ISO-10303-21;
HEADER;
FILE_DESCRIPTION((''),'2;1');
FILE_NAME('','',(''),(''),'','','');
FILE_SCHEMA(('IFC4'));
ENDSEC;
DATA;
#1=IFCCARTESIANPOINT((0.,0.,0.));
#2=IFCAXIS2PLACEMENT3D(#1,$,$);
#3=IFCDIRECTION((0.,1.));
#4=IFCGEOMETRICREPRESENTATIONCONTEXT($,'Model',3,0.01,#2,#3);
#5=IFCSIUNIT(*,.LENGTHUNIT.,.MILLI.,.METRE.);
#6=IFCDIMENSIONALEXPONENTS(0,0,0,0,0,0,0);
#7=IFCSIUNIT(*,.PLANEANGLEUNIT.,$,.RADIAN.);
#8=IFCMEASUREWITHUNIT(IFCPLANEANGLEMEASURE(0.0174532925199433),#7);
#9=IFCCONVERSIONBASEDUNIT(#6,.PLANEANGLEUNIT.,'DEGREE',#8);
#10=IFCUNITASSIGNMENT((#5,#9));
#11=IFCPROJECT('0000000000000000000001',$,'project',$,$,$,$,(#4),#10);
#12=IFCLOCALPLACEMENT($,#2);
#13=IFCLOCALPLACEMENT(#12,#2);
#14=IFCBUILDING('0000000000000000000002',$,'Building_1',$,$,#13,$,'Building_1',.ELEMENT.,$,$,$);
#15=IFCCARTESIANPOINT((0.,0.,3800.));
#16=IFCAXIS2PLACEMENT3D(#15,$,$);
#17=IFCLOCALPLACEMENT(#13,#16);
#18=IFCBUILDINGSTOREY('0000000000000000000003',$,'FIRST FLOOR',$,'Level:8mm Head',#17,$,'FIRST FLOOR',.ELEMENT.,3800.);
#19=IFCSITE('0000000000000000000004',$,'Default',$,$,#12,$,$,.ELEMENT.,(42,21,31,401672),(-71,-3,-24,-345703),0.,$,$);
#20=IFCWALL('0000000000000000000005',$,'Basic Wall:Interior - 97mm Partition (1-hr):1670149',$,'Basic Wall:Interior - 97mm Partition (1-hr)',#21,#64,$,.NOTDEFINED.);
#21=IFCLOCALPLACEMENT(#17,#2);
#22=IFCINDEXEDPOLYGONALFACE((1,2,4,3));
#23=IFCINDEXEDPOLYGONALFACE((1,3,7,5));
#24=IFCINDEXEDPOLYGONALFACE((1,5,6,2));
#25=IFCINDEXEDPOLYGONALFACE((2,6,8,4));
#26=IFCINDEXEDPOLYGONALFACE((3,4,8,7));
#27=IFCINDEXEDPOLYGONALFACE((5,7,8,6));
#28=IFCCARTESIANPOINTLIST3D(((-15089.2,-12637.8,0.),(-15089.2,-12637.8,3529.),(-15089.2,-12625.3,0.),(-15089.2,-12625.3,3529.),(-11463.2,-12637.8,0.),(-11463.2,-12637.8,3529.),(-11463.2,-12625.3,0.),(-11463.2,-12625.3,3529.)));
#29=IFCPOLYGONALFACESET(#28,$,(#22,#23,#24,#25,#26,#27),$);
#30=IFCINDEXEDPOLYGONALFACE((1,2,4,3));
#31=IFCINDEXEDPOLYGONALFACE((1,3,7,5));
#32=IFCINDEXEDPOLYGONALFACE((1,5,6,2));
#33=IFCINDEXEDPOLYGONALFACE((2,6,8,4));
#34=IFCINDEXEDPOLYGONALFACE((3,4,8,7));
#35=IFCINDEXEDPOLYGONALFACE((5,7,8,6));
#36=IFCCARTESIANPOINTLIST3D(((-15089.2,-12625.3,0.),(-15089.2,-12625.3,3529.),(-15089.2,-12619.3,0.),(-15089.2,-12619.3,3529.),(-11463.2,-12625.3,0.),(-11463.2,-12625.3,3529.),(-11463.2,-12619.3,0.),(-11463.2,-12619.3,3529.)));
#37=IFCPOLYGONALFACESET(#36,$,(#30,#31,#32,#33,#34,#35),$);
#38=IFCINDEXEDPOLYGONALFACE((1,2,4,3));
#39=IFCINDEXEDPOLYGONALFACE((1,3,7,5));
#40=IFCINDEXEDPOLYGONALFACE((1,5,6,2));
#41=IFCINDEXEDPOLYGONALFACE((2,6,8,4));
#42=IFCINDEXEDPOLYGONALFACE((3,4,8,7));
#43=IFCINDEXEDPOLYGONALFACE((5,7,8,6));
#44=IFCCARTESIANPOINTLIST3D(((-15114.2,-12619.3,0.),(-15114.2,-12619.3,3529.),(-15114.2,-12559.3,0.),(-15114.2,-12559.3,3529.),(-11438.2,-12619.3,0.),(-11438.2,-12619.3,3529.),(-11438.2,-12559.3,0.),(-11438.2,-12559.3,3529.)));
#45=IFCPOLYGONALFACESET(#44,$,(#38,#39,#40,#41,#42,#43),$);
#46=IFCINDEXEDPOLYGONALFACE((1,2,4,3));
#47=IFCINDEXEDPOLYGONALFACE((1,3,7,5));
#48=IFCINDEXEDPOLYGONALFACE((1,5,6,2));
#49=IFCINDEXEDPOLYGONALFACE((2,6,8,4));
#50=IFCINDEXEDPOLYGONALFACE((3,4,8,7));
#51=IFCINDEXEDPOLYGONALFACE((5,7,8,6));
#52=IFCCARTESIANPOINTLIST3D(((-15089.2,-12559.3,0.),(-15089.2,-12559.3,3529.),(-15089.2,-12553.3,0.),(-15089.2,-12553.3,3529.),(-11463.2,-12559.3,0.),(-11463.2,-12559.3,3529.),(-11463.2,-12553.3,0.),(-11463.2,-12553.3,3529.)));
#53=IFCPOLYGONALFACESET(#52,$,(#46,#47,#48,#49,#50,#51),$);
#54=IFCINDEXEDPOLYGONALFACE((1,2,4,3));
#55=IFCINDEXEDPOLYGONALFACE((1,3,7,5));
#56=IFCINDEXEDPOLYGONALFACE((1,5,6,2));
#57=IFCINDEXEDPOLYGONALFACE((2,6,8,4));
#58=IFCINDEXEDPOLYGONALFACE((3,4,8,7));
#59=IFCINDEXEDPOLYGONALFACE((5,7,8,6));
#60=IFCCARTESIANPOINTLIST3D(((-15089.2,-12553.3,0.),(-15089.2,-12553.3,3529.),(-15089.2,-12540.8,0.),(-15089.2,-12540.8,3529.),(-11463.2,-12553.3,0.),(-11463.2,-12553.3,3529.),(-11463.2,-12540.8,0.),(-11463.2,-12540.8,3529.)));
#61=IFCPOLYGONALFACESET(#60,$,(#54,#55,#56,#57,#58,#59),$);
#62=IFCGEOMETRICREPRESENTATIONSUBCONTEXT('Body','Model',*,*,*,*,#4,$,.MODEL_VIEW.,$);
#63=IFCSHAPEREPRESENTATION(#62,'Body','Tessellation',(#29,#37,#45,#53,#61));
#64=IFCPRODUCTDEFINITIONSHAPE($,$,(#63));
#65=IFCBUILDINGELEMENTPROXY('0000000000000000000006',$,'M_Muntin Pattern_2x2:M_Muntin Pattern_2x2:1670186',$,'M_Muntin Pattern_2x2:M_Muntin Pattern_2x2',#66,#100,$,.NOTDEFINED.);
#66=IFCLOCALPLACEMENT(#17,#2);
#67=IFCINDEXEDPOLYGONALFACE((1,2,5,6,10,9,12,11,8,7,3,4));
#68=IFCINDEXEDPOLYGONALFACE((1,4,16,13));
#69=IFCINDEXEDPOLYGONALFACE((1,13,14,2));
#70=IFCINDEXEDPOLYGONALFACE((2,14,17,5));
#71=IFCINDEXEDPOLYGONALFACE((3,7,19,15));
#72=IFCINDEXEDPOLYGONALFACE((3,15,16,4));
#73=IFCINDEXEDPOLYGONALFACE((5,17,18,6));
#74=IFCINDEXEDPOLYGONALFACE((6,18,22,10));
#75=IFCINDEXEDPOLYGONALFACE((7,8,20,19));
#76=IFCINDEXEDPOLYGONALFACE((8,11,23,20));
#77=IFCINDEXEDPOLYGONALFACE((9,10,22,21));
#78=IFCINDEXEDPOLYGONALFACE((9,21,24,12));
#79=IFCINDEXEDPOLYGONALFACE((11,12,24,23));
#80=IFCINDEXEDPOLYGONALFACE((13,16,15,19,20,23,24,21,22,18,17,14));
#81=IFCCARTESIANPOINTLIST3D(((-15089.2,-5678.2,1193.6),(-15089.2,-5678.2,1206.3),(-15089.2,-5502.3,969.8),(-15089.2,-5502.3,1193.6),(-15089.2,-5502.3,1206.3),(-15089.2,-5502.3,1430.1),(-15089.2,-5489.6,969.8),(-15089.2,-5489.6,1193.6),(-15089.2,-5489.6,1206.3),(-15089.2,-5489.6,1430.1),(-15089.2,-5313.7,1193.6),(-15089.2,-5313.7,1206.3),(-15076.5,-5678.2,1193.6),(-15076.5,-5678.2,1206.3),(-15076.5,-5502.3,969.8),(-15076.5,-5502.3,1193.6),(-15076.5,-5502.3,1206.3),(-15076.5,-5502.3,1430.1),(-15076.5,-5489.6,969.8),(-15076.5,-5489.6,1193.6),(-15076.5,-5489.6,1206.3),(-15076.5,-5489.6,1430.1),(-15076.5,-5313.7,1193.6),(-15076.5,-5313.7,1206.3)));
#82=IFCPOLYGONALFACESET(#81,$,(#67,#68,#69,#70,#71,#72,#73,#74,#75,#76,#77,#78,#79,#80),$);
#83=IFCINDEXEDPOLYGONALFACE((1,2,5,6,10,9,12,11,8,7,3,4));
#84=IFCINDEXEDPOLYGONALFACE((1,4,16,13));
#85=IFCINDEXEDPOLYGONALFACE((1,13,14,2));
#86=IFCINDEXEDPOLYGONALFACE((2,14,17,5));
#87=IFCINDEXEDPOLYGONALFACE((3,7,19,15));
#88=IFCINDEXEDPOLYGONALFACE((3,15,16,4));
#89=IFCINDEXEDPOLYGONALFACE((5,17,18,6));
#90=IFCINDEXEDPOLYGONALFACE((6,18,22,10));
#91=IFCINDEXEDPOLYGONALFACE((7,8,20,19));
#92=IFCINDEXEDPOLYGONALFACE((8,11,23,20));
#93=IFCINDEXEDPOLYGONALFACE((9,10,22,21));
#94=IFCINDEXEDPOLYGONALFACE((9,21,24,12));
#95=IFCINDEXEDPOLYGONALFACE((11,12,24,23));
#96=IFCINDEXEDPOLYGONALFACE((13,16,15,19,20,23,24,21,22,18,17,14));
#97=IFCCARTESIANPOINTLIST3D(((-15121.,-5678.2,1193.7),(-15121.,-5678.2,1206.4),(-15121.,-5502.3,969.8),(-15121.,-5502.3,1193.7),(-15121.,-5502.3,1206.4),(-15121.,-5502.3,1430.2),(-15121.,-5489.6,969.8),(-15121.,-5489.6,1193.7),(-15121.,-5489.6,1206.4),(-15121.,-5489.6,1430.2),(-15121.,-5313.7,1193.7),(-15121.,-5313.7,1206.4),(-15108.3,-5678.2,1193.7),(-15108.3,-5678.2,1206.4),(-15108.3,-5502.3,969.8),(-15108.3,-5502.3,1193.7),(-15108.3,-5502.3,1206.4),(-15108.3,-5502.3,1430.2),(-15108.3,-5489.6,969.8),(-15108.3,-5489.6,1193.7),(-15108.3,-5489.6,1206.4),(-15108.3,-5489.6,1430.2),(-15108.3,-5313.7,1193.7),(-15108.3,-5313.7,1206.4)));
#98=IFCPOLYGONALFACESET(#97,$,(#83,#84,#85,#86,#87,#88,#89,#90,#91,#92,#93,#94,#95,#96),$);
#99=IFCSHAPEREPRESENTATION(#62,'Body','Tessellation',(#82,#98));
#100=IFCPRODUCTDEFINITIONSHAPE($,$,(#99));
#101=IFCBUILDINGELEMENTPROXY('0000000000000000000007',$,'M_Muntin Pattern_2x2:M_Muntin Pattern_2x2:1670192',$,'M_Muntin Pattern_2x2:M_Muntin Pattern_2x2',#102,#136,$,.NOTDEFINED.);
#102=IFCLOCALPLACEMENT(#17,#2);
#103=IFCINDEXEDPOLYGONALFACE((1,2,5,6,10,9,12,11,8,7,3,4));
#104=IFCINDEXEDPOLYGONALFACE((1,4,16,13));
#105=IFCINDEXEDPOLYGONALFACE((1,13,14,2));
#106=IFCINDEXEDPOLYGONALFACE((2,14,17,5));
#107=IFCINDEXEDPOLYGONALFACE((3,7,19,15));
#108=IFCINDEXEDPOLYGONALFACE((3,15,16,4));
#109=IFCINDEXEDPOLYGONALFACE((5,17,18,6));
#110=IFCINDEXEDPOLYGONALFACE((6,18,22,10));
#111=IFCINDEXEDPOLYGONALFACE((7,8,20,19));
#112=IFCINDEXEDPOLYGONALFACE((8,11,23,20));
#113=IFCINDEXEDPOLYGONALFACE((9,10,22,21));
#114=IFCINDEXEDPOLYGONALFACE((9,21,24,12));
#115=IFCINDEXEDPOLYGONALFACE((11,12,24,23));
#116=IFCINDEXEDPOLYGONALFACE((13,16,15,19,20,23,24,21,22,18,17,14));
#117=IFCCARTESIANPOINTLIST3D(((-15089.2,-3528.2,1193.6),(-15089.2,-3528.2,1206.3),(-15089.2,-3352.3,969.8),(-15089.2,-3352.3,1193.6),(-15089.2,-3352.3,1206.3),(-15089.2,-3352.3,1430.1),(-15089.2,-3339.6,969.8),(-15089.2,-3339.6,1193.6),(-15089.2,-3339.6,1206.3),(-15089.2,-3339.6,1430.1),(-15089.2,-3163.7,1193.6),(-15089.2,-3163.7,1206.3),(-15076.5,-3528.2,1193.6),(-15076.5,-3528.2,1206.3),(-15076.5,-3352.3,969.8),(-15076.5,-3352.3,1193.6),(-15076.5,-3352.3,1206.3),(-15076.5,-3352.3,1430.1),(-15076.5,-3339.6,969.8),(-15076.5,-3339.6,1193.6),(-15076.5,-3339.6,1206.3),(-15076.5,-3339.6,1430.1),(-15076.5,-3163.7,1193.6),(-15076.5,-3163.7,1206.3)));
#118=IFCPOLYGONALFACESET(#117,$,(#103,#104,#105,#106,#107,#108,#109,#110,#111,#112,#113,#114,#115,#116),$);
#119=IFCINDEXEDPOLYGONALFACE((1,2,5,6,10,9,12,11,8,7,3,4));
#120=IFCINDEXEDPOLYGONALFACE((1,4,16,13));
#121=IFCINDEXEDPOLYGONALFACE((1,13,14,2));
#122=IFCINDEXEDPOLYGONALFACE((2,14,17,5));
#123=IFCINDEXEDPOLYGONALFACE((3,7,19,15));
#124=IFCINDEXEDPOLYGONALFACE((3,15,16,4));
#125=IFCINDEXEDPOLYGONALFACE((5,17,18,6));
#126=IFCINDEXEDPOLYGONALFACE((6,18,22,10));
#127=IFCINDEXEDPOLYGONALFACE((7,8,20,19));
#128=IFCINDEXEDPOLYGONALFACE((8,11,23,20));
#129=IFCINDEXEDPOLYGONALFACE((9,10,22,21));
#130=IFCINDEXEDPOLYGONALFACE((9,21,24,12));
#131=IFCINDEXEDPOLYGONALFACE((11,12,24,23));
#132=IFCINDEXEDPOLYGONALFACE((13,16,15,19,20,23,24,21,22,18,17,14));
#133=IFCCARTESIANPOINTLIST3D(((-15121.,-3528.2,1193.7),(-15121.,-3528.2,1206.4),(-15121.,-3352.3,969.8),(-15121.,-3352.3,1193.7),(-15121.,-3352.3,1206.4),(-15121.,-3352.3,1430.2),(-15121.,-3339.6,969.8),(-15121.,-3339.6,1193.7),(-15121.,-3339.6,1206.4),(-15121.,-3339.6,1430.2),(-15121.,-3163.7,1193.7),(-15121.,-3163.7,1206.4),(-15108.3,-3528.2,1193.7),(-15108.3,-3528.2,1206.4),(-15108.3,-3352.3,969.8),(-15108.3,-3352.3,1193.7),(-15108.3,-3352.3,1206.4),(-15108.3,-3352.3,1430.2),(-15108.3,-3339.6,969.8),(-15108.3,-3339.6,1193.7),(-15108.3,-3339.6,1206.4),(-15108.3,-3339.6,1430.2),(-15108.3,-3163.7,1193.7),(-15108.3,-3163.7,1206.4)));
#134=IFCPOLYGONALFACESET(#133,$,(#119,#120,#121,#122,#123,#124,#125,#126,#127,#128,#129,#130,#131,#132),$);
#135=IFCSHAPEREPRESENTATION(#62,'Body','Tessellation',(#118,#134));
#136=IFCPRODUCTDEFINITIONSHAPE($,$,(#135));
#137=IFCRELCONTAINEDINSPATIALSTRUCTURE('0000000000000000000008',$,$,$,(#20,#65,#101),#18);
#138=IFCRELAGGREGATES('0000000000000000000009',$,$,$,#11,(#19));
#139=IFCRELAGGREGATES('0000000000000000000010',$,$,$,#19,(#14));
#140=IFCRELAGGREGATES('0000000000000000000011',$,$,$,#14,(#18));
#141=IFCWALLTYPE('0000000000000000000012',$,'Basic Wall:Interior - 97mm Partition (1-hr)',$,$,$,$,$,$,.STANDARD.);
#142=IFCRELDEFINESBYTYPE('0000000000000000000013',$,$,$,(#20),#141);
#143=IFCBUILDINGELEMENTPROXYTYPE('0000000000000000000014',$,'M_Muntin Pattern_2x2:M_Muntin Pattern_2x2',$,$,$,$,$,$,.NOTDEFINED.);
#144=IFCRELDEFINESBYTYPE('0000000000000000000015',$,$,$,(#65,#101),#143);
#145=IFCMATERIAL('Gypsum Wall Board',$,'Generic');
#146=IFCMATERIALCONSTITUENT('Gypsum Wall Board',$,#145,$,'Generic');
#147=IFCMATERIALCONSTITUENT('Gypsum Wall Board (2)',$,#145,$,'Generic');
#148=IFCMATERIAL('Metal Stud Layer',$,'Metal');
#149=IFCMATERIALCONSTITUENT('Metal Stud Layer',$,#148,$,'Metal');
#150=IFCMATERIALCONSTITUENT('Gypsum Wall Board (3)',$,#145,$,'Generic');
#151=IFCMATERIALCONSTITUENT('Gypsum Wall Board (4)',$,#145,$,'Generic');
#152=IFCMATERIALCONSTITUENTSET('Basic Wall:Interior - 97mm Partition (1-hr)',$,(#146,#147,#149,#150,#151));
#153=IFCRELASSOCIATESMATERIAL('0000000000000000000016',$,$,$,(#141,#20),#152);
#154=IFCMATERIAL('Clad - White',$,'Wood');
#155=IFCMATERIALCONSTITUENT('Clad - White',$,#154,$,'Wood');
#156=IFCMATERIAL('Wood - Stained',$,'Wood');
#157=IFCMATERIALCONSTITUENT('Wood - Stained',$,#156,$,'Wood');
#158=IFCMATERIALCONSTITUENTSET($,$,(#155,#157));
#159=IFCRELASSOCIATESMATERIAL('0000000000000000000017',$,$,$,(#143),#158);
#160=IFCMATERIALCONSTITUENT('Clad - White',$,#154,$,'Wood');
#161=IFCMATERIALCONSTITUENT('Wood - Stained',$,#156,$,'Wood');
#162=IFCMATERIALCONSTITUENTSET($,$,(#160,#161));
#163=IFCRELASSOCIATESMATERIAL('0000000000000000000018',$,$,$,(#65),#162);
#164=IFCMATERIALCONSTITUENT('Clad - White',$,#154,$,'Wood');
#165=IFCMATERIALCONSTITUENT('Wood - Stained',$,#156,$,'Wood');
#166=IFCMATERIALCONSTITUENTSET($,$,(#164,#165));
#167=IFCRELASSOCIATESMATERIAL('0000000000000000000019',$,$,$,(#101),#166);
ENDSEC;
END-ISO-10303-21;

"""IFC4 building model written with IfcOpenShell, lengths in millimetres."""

from ifc_helpers import new_model, entity, si_unit, converted_unit, direction, frame, origin, place, context, subcontext, project, spatial, indexed_curve, outline, extrude, source, transform, mapped, material, constituent, constituent_set, type_object, type_shapes, element, save


model = new_model("IFC4")

# Units and contexts
model_context = context("Model", 3, precision=0.01, world=origin(), true_north=direction((0.0, 1.0)))
body_context = subcontext(model_context, "Body", "Model", "MODEL_VIEW")
ifc_project = project(units=[si_unit("LENGTHUNIT", "METRE", prefix="MILLI"), converted_unit("PLANEANGLEUNIT", "DEGREE", entity("IfcPlaneAngleMeasure", 0.0174532925199433), si_unit("PLANEANGLEUNIT", "RADIAN"), dimensions=[0, 0, 0, 0, 0, 0, 0])], contexts=[model_context])

# Site, building, storey
site_placement = place(None, origin())
site = spatial("IfcSite", under=ifc_project, at=site_placement, Name="Default", CompositionType="ELEMENT", RefLatitude=(42, 21, 31, 401672), RefLongitude=(-71, -3, -24, -345703), RefElevation=0.0)
building_placement = place(site_placement, origin())
building = spatial("IfcBuilding", under=site, at=building_placement, Name="Building_1", LongName="Building_1", CompositionType="ELEMENT")
storey_placement = place(building_placement, frame((0.0, 0.0, 3800.0)))
storey = spatial("IfcBuildingStorey", under=building, at=storey_placement, Name="FIRST FLOOR", ObjectType="Level:8mm Head", LongName="FIRST FLOOR", CompositionType="ELEMENT", Elevation=3800.0)

# Shared definitions
ifc_material_1 = material(Name="Wood - Stained", Category="Wood")

# Wall
ifc_material_2 = material(Name="Gypsum Wall Board", Category="Generic")
ifc_constituent_1 = constituent(ifc_material_2, Name="Gypsum Wall Board", Category="Generic")
ifc_constituent_2 = constituent(ifc_material_2, Name="Gypsum Wall Board (2)", Category="Generic")
ifc_material_3 = material(Name="Metal Stud Layer", Category="Metal")
ifc_constituent_3 = constituent(ifc_material_3, Name="Metal Stud Layer", Category="Metal")
ifc_constituent_4 = constituent(ifc_material_2, Name="Gypsum Wall Board (3)", Category="Generic")
ifc_constituent_5 = constituent(ifc_material_2, Name="Gypsum Wall Board (4)", Category="Generic")
ifc_constituent_set_1 = constituent_set(constituents=[ifc_constituent_1, ifc_constituent_2, ifc_constituent_3, ifc_constituent_4, ifc_constituent_5], Name="Basic Wall:Interior - 97mm Partition (1-hr)")
wall_type_1 = type_object("IfcWallType", Name="Basic Wall:Interior - 97mm Partition (1-hr)", PredefinedType="STANDARD", material=ifc_constituent_set_1)
wall_1_placement = place(storey_placement, frame((-15089.2, -12589.3, 0.0)))
element("IfcWall", 1, at=wall_1_placement, inside=storey, type_object=wall_type_1, material=ifc_constituent_set_1, Name="Basic Wall:Interior - 97mm Partition (1-hr):1670149", ObjectType="Basic Wall:Interior - 97mm Partition (1-hr)", PredefinedType="NOTDEFINED", context=body_context, shape_type="SweptSolid", body=[
    extrude(outline(indexed_curve([(-6.3, -1813.0), (6.2, -1813.0), (6.3, 1813.0), (-6.2, 1813.0), (-6.3, -1813.0)], self_intersect=False)), frame((1813.0, -42.2, 0.0), z_axis=(0.0, 0.0, 1.0), x_axis=(0.0, 1.0, 0.0)), (0.0, 0.0, 1.0), 3529.0),
    extrude(outline(indexed_curve([(-1813.0, -3.0), (1813.0, -3.0), (1813.0, 3.0), (-1813.0, 3.0), (-1813.0, -3.0)], self_intersect=False)), frame((1813.0, -33.0, 0.0)), (0.0, 0.0, 1.0), 3529.0),
    extrude(outline(indexed_curve([(-1838.0, -30.0), (1838.0, -30.0), (1838.0, 30.0), (-1838.0, 30.0), (-1838.0, -30.0)], self_intersect=False)), frame((1813.0, 0.0, 0.0)), (0.0, 0.0, 1.0), 3529.0),
    extrude(outline(indexed_curve([(-1813.0, -3.0), (1813.0, -3.0), (1813.0, 3.0), (-1813.0, 3.0), (-1813.0, -3.0)], self_intersect=False)), frame((1813.0, 33.0, 0.0)), (0.0, 0.0, 1.0), 3529.0),
    extrude(outline(indexed_curve([(-6.3, -1813.0), (6.2, -1813.0), (6.3, 1813.0), (-6.2, 1813.0), (-6.3, -1813.0)], self_intersect=False)), frame((1813.0, 42.2, 0.0), z_axis=(0.0, 0.0, 1.0), x_axis=(0.0, -1.0, 0.0)), (0.0, 0.0, 1.0), 3529.0),
])

# Building element proxies
ifc_material_4 = material(Name="Clad - White", Category="Wood")
ifc_constituent_6 = constituent(ifc_material_4, Name="Clad - White", Category="Wood")
ifc_constituent_7 = constituent(ifc_material_1, Name="Wood - Stained", Category="Wood")
ifc_constituent_set_2 = constituent_set(constituents=[ifc_constituent_6, ifc_constituent_7])
ifc_constituent_8 = constituent(ifc_material_4, Name="Clad - White", Category="Wood")
ifc_constituent_9 = constituent(ifc_material_1, Name="Wood - Stained", Category="Wood")
ifc_constituent_set_3 = constituent_set(constituents=[ifc_constituent_8, ifc_constituent_9])
building_element_proxy_type_1 = type_object("IfcBuildingElementProxyType", Name="M_Muntin Pattern_2x2:M_Muntin Pattern_2x2", PredefinedType="NOTDEFINED", material=ifc_constituent_set_3)
shared_shape_1 = source(origin(), body_context, "Body", "SweptSolid", [
    extrude(outline(indexed_curve([(6.4, -6.4), (230.1, -6.4), (230.1, 6.3), (6.4, 6.3), (6.4, 182.3), (-6.3, 182.3), (-6.3, 6.3), (-230.2, 6.3), (-230.2, -6.4), (-6.3, -6.4), (-6.3, -182.3), (6.4, -182.3), (6.4, -6.4)], self_intersect=False)), frame((0.0, 9.5, 230.1), z_axis=(0.0, 1.0, 0.0), x_axis=(0.0, 0.0, 1.0)), (0.0, 0.0, 1.0), 12.7),
    extrude(outline(indexed_curve([(6.4, -6.4), (230.2, -6.4), (230.2, 6.3), (6.4, 6.3), (6.4, 182.3), (-6.3, 182.3), (-6.3, 6.3), (-230.2, 6.3), (-230.2, -6.4), (-6.3, -6.4), (-6.3, -182.3), (6.4, -182.3), (6.4, -6.4)], self_intersect=False)), frame((0.0, -22.2, 230.2), z_axis=(0.0, 1.0, 0.0), x_axis=(0.0, 0.0, 1.0)), (0.0, 0.0, 1.0), 12.7),
])
type_shapes(building_element_proxy_type_1, [shared_shape_1])
proxy_1_placement = place(storey_placement, frame((-15098.7, -5495.9, 969.8), z_axis=(0.0, 0.0, 1.0), x_axis=(0.0, -1.0, 0.0)))
element("IfcBuildingElementProxy", 2, at=proxy_1_placement, inside=storey, type_object=building_element_proxy_type_1, material=ifc_constituent_set_2, Name="M_Muntin Pattern_2x2:M_Muntin Pattern_2x2:1670186", ObjectType="M_Muntin Pattern_2x2:M_Muntin Pattern_2x2", PredefinedType="NOTDEFINED", context=body_context, shape_type="MappedRepresentation", body=[
    mapped(shared_shape_1, transform((0.0, 0.0, 0.0), scale=1.0)),
])
ifc_constituent_10 = constituent(ifc_material_4, Name="Clad - White", Category="Wood")
ifc_constituent_11 = constituent(ifc_material_1, Name="Wood - Stained", Category="Wood")
ifc_constituent_set_4 = constituent_set(constituents=[ifc_constituent_10, ifc_constituent_11])
proxy_2_placement = place(storey_placement, frame((-15098.7, -3345.9, 969.8), z_axis=(0.0, 0.0, 1.0), x_axis=(0.0, -1.0, 0.0)))
element("IfcBuildingElementProxy", 3, at=proxy_2_placement, inside=storey, type_object=building_element_proxy_type_1, material=ifc_constituent_set_4, Name="M_Muntin Pattern_2x2:M_Muntin Pattern_2x2:1670192", ObjectType="M_Muntin Pattern_2x2:M_Muntin Pattern_2x2", PredefinedType="NOTDEFINED", context=body_context, shape_type="MappedRepresentation", body=[
    mapped(shared_shape_1, transform((0.0, 0.0, 0.0), scale=1.0)),
])

save(model, "model.ifc")
